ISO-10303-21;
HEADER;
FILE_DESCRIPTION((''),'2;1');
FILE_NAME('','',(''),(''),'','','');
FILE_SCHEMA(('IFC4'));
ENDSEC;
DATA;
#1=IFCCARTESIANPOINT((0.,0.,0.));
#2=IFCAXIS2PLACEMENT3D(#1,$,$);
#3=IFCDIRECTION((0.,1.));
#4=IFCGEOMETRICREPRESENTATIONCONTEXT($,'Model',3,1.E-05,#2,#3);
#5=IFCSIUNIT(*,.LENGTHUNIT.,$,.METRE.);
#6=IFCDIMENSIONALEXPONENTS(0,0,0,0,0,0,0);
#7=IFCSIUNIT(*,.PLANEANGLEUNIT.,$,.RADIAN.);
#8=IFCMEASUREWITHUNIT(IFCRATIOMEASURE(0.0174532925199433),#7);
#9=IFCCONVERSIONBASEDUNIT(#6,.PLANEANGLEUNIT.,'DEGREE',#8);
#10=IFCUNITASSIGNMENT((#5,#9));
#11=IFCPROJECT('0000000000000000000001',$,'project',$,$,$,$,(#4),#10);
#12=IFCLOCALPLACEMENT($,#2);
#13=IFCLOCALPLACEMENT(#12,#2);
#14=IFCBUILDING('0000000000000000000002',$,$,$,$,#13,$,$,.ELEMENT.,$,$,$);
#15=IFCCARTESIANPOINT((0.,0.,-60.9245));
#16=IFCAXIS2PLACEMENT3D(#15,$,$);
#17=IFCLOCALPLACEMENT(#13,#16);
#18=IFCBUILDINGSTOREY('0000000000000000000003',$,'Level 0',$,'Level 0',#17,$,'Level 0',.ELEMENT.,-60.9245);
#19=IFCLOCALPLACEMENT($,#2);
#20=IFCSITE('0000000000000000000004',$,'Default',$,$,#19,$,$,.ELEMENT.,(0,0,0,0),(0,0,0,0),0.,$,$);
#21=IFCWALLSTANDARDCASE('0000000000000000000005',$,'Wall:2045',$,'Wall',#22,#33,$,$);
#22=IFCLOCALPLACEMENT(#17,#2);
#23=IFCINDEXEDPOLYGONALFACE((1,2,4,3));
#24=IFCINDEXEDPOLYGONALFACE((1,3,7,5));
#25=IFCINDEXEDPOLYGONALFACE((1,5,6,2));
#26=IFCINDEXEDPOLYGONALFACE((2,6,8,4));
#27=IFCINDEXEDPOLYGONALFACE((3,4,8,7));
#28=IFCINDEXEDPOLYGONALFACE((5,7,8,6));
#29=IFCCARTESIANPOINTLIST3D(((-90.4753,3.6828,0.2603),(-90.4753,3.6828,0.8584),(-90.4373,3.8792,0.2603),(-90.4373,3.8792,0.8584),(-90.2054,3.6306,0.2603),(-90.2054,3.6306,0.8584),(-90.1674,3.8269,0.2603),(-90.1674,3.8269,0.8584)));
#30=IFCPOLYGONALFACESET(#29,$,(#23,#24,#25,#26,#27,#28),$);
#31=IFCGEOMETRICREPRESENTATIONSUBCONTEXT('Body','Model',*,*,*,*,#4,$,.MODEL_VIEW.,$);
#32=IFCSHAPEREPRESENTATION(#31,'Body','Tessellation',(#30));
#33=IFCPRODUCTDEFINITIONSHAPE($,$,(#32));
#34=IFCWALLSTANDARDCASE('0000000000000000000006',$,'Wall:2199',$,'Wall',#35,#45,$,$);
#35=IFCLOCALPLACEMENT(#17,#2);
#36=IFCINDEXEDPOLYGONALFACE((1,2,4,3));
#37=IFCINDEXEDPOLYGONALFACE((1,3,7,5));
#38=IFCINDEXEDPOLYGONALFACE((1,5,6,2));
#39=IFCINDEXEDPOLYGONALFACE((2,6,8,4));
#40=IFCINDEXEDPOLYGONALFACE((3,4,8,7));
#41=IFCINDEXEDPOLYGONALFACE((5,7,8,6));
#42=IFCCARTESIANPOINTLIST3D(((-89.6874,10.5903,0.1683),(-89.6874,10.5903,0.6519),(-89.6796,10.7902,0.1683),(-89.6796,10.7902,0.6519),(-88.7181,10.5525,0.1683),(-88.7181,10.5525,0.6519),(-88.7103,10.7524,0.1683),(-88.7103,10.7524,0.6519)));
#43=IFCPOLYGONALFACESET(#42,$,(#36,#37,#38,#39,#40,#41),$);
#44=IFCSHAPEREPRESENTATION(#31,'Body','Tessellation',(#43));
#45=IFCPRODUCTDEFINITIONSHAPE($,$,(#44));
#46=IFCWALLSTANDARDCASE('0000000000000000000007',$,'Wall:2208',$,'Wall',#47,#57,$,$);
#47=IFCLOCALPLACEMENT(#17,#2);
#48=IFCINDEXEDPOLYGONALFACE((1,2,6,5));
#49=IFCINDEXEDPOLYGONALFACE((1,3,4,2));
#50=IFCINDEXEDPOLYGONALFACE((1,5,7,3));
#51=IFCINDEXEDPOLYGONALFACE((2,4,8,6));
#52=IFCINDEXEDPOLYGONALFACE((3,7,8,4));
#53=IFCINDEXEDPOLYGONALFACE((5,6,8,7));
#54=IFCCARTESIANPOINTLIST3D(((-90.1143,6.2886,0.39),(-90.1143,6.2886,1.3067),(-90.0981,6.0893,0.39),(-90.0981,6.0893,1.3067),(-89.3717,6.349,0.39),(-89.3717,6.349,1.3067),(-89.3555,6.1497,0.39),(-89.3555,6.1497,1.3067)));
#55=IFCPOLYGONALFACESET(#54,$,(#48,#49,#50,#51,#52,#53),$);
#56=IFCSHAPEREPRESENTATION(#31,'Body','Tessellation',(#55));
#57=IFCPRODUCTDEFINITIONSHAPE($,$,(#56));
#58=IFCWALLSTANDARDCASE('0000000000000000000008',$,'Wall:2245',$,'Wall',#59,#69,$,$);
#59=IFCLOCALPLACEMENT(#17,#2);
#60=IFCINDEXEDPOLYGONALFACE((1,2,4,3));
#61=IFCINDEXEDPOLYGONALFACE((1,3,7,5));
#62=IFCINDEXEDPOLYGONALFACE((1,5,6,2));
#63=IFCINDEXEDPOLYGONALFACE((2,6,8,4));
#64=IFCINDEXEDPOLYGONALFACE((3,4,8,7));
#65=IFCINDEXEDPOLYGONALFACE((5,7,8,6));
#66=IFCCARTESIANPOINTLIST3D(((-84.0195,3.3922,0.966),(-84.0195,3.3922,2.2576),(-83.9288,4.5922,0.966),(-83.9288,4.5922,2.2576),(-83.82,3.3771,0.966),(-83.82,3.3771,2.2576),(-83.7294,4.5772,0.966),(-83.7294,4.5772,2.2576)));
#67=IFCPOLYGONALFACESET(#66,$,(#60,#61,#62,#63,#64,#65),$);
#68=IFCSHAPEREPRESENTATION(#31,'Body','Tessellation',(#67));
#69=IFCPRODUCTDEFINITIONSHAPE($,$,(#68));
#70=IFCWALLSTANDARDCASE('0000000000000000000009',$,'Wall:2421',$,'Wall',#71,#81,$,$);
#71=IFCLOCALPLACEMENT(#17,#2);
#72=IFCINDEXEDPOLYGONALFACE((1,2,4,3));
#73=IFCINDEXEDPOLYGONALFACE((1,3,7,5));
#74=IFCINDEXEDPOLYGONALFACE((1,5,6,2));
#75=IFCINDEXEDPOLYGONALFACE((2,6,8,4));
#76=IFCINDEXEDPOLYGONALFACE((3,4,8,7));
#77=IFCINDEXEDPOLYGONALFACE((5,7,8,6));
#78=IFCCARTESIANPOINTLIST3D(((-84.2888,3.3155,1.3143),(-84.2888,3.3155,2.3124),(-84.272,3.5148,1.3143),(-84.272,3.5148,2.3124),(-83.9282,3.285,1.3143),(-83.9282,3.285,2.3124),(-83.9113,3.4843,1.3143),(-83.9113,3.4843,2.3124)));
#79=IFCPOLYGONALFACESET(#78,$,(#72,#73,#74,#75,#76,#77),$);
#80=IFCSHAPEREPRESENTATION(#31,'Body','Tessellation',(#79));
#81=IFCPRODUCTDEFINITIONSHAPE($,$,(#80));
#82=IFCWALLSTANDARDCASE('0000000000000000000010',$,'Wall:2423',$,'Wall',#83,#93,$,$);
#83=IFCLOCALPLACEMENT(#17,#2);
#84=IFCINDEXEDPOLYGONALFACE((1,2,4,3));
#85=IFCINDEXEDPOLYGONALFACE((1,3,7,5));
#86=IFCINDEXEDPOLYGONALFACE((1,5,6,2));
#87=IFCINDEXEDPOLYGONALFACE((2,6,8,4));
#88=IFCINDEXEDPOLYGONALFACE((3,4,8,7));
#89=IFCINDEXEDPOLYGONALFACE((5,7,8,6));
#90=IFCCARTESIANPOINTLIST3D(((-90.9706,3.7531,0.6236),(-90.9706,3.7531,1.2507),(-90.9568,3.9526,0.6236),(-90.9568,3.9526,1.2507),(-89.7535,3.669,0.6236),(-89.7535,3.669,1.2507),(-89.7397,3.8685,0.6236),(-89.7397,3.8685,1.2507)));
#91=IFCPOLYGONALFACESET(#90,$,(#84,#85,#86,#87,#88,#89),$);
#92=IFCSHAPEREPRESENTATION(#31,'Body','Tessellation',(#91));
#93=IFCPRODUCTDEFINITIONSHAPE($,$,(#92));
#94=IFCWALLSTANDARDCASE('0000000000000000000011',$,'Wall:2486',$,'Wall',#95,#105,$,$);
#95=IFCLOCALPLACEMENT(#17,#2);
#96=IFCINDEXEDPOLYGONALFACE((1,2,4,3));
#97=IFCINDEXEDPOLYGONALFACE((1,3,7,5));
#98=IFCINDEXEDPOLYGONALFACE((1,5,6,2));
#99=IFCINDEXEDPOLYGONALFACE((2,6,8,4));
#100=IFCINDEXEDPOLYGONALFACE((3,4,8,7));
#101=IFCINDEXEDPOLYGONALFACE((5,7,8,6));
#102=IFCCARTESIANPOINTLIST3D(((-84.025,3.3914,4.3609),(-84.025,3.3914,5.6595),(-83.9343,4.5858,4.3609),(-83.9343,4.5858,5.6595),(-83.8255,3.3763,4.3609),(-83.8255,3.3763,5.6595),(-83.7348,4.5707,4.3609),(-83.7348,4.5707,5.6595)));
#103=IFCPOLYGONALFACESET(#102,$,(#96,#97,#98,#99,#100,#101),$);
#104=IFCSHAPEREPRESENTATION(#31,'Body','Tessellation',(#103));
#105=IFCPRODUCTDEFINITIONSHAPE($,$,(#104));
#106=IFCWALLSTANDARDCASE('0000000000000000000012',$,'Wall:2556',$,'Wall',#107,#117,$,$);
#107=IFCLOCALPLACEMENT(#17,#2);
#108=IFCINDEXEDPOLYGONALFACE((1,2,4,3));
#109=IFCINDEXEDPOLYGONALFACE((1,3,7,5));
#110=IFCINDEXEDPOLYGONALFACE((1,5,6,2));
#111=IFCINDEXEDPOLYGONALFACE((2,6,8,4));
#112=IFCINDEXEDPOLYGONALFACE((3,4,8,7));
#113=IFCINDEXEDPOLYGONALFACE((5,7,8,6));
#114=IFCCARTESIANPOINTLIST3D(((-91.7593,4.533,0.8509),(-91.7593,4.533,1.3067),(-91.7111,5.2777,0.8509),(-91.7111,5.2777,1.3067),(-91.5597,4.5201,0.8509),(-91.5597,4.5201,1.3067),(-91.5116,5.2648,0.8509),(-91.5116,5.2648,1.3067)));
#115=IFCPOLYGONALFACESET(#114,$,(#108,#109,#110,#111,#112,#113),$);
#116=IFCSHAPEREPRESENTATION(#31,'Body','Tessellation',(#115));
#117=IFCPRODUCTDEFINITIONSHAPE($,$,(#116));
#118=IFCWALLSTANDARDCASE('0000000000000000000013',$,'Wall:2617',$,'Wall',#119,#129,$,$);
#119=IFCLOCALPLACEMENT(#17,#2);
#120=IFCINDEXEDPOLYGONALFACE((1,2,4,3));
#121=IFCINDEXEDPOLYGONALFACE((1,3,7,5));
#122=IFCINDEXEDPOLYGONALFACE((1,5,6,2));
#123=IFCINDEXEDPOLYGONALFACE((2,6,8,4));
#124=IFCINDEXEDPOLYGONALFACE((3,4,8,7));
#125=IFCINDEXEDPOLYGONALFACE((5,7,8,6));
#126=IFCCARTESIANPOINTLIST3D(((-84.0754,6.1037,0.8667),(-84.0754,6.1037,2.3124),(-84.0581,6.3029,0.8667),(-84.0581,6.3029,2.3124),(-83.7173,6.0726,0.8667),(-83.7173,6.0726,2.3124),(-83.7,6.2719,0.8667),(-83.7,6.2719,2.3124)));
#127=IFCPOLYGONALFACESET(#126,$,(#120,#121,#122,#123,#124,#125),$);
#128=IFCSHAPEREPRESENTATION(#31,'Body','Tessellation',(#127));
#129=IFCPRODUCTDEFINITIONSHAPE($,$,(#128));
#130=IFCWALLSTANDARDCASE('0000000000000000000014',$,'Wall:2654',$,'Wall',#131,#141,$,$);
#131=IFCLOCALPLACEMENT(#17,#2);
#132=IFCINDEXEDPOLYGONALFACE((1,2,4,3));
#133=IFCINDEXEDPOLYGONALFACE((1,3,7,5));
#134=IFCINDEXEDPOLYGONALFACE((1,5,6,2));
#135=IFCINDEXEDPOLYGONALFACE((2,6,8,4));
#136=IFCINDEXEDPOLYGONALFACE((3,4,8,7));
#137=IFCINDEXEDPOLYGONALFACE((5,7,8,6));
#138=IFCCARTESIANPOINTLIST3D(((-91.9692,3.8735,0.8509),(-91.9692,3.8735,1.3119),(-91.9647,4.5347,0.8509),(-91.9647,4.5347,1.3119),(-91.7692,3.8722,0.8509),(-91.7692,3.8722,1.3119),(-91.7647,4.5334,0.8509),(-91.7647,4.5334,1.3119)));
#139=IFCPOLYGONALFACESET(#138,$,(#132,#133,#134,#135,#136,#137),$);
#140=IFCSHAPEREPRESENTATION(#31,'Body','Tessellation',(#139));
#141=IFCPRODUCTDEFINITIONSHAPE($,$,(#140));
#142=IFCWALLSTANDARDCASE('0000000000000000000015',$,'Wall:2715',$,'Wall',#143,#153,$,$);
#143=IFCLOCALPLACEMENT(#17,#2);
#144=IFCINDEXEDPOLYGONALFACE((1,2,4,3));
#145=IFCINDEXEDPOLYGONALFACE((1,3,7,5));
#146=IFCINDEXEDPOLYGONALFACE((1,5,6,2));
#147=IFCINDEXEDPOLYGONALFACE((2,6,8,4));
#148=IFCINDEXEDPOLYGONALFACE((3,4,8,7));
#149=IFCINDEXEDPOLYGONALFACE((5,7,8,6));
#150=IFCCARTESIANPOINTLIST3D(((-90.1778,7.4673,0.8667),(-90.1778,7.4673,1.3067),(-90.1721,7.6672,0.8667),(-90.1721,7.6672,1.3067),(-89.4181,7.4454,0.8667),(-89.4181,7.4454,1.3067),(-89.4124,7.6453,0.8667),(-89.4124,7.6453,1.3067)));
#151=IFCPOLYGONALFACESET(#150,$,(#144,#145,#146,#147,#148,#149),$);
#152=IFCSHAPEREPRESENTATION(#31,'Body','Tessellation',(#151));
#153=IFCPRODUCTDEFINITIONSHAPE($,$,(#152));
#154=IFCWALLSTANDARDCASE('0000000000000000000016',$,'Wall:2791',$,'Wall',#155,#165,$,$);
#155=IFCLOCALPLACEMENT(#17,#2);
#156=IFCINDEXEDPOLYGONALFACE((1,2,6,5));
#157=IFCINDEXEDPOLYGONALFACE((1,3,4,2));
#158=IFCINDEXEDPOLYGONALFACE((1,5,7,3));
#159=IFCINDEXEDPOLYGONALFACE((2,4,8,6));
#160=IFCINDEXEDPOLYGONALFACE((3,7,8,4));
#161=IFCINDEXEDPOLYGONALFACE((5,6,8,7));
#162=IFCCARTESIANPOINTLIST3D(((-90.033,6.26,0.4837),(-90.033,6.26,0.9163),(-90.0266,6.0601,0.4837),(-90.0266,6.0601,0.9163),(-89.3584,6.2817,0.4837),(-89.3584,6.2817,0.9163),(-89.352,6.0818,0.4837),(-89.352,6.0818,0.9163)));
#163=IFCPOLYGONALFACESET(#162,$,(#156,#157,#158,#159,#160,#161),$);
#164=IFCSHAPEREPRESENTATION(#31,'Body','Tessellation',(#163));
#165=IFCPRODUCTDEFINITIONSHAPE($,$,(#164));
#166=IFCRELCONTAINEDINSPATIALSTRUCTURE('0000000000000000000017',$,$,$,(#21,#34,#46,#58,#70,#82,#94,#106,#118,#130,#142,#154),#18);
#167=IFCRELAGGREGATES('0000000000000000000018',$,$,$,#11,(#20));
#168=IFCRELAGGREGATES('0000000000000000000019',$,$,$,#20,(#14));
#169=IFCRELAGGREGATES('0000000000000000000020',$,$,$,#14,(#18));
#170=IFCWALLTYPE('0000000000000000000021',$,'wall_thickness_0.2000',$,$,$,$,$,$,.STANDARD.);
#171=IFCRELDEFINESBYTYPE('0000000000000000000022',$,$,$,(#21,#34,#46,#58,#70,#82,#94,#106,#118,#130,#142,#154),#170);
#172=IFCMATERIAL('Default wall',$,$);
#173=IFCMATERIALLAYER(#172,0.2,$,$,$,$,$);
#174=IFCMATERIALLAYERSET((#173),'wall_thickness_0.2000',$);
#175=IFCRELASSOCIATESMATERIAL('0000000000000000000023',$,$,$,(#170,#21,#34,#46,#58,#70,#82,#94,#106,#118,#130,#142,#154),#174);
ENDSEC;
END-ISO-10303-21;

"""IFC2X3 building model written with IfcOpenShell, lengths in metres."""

from ifc_helpers import new_model, entity, si_unit, converted_unit, direction, frame, origin, place, context, subcontext, project, spatial, polyline, outline, extrude, material, layer, layer_set, layer_usage, type_object, element, save


model = new_model("IFC2X3")

# Units and contexts
model_context = context("Model", 3, precision=1e-05, world=origin(), true_north=direction((0.0, 1.0)))
body_context = subcontext(model_context, "Body", "Model", "MODEL_VIEW")
ifc_project = project(units=[si_unit("LENGTHUNIT", "METRE"), converted_unit("PLANEANGLEUNIT", "DEGREE", entity("IfcRatioMeasure", 0.0174532925199433), si_unit("PLANEANGLEUNIT", "RADIAN"), dimensions=[0, 0, 0, 0, 0, 0, 0])], contexts=[model_context])

# Site, building, storey
site_placement = place(None, origin())
site = spatial("IfcSite", under=ifc_project, at=site_placement, Name="Default", CompositionType="ELEMENT", RefLatitude=(0, 0, 0, 0), RefLongitude=(0, 0, 0, 0), RefElevation=0.0)
placement_1 = place(None, origin())
building_placement = place(placement_1, origin())
building = spatial("IfcBuilding", under=site, at=building_placement, CompositionType="ELEMENT")
storey_placement = place(building_placement, frame((0.0, 0.0, -60.9245)))
storey = spatial("IfcBuildingStorey", under=building, at=storey_placement, Name="Level 0", ObjectType="Level 0", LongName="Level 0", CompositionType="ELEMENT", Elevation=-60.9245)

# Walls
ifc_material = material(Name="Default wall")
ifc_layer = layer(ifc_material, 0.2)
ifc_layer_set = layer_set([ifc_layer], Name="wall_thickness_0.2000")
ifc_layer_usage = layer_usage(ifc_layer_set, "AXIS2", "POSITIVE", -0.1)
wall_type = type_object("IfcWallType", Name="wall_thickness_0.2000", PredefinedType="STANDARD", material=ifc_layer_set)
placement_2 = place(building_placement, frame((0.0, 0.0, -60.6642)))
wall_1_placement = place(placement_2, frame((-90.1864, 3.7287, 0.0), z_axis=(0.0, 0.0, 1.0), x_axis=(-0.981781, 0.190017, 0.0)))
element("IfcWallStandardCase", 1, at=wall_1_placement, inside=storey, type_object=wall_type, material=ifc_layer_usage, Name="Wall:2045", ObjectType="Wall", context=body_context, shape_type="SweptSolid", body=[
    extrude(outline(polyline([(0.275, -0.1), (0.275, 0.1), (0.0, 0.1), (0.0, -0.1), (0.275, -0.1)])), origin(), (0.0, 0.0, 1.0), 0.5981),
])
placement_3 = place(building_placement, frame((0.0, 0.0, -60.7562)))
wall_2_placement = place(placement_3, frame((-89.6835, 10.6903, 0.0), z_axis=(0.0, 0.0, 1.0), x_axis=(0.99924, -0.038972, 0.0)))
element("IfcWallStandardCase", 2, at=wall_2_placement, inside=storey, type_object=wall_type, material=ifc_layer_usage, Name="Wall:2199", ObjectType="Wall", context=body_context, shape_type="SweptSolid", body=[
    extrude(outline(polyline([(0.97, -0.1), (0.97, 0.1), (0.0, 0.1), (0.0, -0.1), (0.97, -0.1)])), origin(), (0.0, 0.0, 1.0), 0.4835),
])
placement_4 = place(building_placement, frame((0.0, 0.0, -60.5345)))
wall_3_placement = place(placement_4, frame((-89.3636, 6.2493, 0.0), z_axis=(0.0, 0.0, 1.0), x_axis=(-0.996708, -0.081074, 0.0)))
element("IfcWallStandardCase", 3, at=wall_3_placement, inside=storey, type_object=wall_type, material=ifc_layer_usage, Name="Wall:2208", ObjectType="Wall", context=body_context, shape_type="SweptSolid", body=[
    extrude(outline(polyline([(0.745, -0.1), (0.745, 0.1), (0.0, 0.1), (0.0, -0.1), (0.745, -0.1)])), origin(), (0.0, 0.0, 1.0), 0.9167),
])
placement_5 = place(building_placement, frame((0.0, 0.0, -59.9585)))
wall_4_placement = place(placement_5, frame((-83.8291, 4.5847, 0.0), z_axis=(0.0, 0.0, 1.0), x_axis=(-0.075315, -0.99716, 0.0)))
element("IfcWallStandardCase", 4, at=wall_4_placement, inside=storey, type_object=wall_type, material=ifc_layer_usage, Name="Wall:2245", ObjectType="Wall", context=body_context, shape_type="SweptSolid", body=[
    extrude(outline(polyline([(1.2034, -0.1), (1.2034, 0.1), (0.0, 0.1), (0.0, -0.1), (1.2034, -0.1)])), origin(), (0.0, 0.0, 1.0), 1.2916),
])
placement_6 = place(building_placement, frame((0.0, 0.0, -59.6102)))
wall_5_placement = place(placement_6, frame((-83.9198, 3.3847, 0.0), z_axis=(0.0, 0.0, 1.0), x_axis=(-0.996449, 0.084195, 0.0)))
element("IfcWallStandardCase", 5, at=wall_5_placement, inside=storey, type_object=wall_type, material=ifc_layer_usage, Name="Wall:2421", ObjectType="Wall", context=body_context, shape_type="SweptSolid", body=[
    extrude(outline(polyline([(0.3619, -0.1), (0.3619, 0.1), (0.0, 0.1), (0.0, -0.1), (0.3619, -0.1)])), origin(), (0.0, 0.0, 1.0), 0.9981),
])
placement_7 = place(building_placement, frame((0.0, 0.0, -60.3009)))
wall_6_placement = place(placement_7, frame((-90.9637, 3.8529, 0.0), z_axis=(0.0, 0.0, 1.0), x_axis=(0.997622, -0.068924, 0.0)))
element("IfcWallStandardCase", 6, at=wall_6_placement, inside=storey, type_object=wall_type, material=ifc_layer_usage, Name="Wall:2423", ObjectType="Wall", context=body_context, shape_type="SweptSolid", body=[
    extrude(outline(polyline([(1.22, -0.1), (1.22, 0.1), (0.0, 0.1), (0.0, -0.1), (1.22, -0.1)])), origin(), (0.0, 0.0, 1.0), 0.6271),
])
placement_8 = place(building_placement, frame((0.0, 0.0, -56.5636)))
wall_7_placement = place(placement_8, frame((-83.8346, 4.5782, 0.0), z_axis=(0.0, 0.0, 1.0), x_axis=(-0.075715, -0.99713, 0.0)))
element("IfcWallStandardCase", 7, at=wall_7_placement, inside=storey, type_object=wall_type, material=ifc_layer_usage, Name="Wall:2486", ObjectType="Wall", context=body_context, shape_type="SweptSolid", body=[
    extrude(outline(polyline([(1.1978, -0.1), (1.1978, 0.1), (0.0, 0.1), (0.0, -0.1), (1.1978, -0.1)])), origin(), (0.0, 0.0, 1.0), 1.2985),
])
placement_9 = place(building_placement, frame((0.0, 0.0, -60.0736)))
wall_8_placement = place(placement_9, frame((-91.6113, 5.2713, 0.0), z_axis=(0.0, 0.0, 1.0), x_axis=(-0.064573, -0.997913, 0.0)))
element("IfcWallStandardCase", 8, at=wall_8_placement, inside=storey, type_object=wall_type, material=ifc_layer_usage, Name="Wall:2556", ObjectType="Wall", context=body_context, shape_type="SweptSolid", body=[
    extrude(outline(polyline([(0.7462, -0.1), (0.7462, 0.1), (0.0, 0.1), (0.0, -0.1), (0.7462, -0.1)])), origin(), (0.0, 0.0, 1.0), 0.4559),
])
placement_10 = place(building_placement, frame((0.0, 0.0, -60.0578)))
wall_9_placement = place(placement_10, frame((-83.7087, 6.1723, 0.0), z_axis=(0.0, 0.0, 1.0), x_axis=(-0.996261, 0.086391, 0.0)))
element("IfcWallStandardCase", 9, at=wall_9_placement, inside=storey, type_object=wall_type, material=ifc_layer_usage, Name="Wall:2617", ObjectType="Wall", context=body_context, shape_type="SweptSolid", body=[
    extrude(outline(polyline([(0.3594, -0.1), (0.3594, 0.1), (0.0, 0.1), (0.0, -0.1), (0.3594, -0.1)])), origin(), (0.0, 0.0, 1.0), 1.4457),
])
placement_11 = place(building_placement, frame((0.0, 0.0, -60.0736)))
wall_10_placement = place(placement_11, frame((-91.8647, 4.534, 0.0), z_axis=(0.0, 0.0, 1.0), x_axis=(-0.006785, -0.999977, 0.0)))
element("IfcWallStandardCase", 10, at=wall_10_placement, inside=storey, type_object=wall_type, material=ifc_layer_usage, Name="Wall:2654", ObjectType="Wall", context=body_context, shape_type="SweptSolid", body=[
    extrude(outline(polyline([(0.6612, -0.1), (0.6612, 0.1), (0.0, 0.1), (0.0, -0.1), (0.6612, -0.1)])), origin(), (0.0, 0.0, 1.0), 0.461),
])
placement_12 = place(building_placement, frame((0.0, 0.0, -60.0578)))
wall_11_placement = place(placement_12, frame((-90.1749, 7.5672, 0.0), z_axis=(0.0, 0.0, 1.0), x_axis=(0.999586, -0.028774, 0.0)))
element("IfcWallStandardCase", 11, at=wall_11_placement, inside=storey, type_object=wall_type, material=ifc_layer_usage, Name="Wall:2715", ObjectType="Wall", context=body_context, shape_type="SweptSolid", body=[
    extrude(outline(polyline([(0.76, -0.1), (0.76, 0.1), (0.0, 0.1), (0.0, -0.1), (0.76, -0.1)])), origin(), (0.0, 0.0, 1.0), 0.44),
])
placement_13 = place(building_placement, frame((0.0, 0.0, -60.4408)))
wall_12_placement = place(placement_13, frame((-90.0298, 6.1601, 0.0), z_axis=(0.0, 0.0, 1.0), x_axis=(0.999487, 0.032018, 0.0)))
element("IfcWallStandardCase", 12, at=wall_12_placement, inside=storey, type_object=wall_type, material=ifc_layer_usage, Name="Wall:2791", ObjectType="Wall", context=body_context, shape_type="SweptSolid", body=[
    extrude(outline(polyline([(0.675, -0.1), (0.675, 0.1), (0.0, 0.1), (0.0, -0.1), (0.675, -0.1)])), origin(), (0.0, 0.0, 1.0), 0.4326),
])

save(model, "model.ifc")
